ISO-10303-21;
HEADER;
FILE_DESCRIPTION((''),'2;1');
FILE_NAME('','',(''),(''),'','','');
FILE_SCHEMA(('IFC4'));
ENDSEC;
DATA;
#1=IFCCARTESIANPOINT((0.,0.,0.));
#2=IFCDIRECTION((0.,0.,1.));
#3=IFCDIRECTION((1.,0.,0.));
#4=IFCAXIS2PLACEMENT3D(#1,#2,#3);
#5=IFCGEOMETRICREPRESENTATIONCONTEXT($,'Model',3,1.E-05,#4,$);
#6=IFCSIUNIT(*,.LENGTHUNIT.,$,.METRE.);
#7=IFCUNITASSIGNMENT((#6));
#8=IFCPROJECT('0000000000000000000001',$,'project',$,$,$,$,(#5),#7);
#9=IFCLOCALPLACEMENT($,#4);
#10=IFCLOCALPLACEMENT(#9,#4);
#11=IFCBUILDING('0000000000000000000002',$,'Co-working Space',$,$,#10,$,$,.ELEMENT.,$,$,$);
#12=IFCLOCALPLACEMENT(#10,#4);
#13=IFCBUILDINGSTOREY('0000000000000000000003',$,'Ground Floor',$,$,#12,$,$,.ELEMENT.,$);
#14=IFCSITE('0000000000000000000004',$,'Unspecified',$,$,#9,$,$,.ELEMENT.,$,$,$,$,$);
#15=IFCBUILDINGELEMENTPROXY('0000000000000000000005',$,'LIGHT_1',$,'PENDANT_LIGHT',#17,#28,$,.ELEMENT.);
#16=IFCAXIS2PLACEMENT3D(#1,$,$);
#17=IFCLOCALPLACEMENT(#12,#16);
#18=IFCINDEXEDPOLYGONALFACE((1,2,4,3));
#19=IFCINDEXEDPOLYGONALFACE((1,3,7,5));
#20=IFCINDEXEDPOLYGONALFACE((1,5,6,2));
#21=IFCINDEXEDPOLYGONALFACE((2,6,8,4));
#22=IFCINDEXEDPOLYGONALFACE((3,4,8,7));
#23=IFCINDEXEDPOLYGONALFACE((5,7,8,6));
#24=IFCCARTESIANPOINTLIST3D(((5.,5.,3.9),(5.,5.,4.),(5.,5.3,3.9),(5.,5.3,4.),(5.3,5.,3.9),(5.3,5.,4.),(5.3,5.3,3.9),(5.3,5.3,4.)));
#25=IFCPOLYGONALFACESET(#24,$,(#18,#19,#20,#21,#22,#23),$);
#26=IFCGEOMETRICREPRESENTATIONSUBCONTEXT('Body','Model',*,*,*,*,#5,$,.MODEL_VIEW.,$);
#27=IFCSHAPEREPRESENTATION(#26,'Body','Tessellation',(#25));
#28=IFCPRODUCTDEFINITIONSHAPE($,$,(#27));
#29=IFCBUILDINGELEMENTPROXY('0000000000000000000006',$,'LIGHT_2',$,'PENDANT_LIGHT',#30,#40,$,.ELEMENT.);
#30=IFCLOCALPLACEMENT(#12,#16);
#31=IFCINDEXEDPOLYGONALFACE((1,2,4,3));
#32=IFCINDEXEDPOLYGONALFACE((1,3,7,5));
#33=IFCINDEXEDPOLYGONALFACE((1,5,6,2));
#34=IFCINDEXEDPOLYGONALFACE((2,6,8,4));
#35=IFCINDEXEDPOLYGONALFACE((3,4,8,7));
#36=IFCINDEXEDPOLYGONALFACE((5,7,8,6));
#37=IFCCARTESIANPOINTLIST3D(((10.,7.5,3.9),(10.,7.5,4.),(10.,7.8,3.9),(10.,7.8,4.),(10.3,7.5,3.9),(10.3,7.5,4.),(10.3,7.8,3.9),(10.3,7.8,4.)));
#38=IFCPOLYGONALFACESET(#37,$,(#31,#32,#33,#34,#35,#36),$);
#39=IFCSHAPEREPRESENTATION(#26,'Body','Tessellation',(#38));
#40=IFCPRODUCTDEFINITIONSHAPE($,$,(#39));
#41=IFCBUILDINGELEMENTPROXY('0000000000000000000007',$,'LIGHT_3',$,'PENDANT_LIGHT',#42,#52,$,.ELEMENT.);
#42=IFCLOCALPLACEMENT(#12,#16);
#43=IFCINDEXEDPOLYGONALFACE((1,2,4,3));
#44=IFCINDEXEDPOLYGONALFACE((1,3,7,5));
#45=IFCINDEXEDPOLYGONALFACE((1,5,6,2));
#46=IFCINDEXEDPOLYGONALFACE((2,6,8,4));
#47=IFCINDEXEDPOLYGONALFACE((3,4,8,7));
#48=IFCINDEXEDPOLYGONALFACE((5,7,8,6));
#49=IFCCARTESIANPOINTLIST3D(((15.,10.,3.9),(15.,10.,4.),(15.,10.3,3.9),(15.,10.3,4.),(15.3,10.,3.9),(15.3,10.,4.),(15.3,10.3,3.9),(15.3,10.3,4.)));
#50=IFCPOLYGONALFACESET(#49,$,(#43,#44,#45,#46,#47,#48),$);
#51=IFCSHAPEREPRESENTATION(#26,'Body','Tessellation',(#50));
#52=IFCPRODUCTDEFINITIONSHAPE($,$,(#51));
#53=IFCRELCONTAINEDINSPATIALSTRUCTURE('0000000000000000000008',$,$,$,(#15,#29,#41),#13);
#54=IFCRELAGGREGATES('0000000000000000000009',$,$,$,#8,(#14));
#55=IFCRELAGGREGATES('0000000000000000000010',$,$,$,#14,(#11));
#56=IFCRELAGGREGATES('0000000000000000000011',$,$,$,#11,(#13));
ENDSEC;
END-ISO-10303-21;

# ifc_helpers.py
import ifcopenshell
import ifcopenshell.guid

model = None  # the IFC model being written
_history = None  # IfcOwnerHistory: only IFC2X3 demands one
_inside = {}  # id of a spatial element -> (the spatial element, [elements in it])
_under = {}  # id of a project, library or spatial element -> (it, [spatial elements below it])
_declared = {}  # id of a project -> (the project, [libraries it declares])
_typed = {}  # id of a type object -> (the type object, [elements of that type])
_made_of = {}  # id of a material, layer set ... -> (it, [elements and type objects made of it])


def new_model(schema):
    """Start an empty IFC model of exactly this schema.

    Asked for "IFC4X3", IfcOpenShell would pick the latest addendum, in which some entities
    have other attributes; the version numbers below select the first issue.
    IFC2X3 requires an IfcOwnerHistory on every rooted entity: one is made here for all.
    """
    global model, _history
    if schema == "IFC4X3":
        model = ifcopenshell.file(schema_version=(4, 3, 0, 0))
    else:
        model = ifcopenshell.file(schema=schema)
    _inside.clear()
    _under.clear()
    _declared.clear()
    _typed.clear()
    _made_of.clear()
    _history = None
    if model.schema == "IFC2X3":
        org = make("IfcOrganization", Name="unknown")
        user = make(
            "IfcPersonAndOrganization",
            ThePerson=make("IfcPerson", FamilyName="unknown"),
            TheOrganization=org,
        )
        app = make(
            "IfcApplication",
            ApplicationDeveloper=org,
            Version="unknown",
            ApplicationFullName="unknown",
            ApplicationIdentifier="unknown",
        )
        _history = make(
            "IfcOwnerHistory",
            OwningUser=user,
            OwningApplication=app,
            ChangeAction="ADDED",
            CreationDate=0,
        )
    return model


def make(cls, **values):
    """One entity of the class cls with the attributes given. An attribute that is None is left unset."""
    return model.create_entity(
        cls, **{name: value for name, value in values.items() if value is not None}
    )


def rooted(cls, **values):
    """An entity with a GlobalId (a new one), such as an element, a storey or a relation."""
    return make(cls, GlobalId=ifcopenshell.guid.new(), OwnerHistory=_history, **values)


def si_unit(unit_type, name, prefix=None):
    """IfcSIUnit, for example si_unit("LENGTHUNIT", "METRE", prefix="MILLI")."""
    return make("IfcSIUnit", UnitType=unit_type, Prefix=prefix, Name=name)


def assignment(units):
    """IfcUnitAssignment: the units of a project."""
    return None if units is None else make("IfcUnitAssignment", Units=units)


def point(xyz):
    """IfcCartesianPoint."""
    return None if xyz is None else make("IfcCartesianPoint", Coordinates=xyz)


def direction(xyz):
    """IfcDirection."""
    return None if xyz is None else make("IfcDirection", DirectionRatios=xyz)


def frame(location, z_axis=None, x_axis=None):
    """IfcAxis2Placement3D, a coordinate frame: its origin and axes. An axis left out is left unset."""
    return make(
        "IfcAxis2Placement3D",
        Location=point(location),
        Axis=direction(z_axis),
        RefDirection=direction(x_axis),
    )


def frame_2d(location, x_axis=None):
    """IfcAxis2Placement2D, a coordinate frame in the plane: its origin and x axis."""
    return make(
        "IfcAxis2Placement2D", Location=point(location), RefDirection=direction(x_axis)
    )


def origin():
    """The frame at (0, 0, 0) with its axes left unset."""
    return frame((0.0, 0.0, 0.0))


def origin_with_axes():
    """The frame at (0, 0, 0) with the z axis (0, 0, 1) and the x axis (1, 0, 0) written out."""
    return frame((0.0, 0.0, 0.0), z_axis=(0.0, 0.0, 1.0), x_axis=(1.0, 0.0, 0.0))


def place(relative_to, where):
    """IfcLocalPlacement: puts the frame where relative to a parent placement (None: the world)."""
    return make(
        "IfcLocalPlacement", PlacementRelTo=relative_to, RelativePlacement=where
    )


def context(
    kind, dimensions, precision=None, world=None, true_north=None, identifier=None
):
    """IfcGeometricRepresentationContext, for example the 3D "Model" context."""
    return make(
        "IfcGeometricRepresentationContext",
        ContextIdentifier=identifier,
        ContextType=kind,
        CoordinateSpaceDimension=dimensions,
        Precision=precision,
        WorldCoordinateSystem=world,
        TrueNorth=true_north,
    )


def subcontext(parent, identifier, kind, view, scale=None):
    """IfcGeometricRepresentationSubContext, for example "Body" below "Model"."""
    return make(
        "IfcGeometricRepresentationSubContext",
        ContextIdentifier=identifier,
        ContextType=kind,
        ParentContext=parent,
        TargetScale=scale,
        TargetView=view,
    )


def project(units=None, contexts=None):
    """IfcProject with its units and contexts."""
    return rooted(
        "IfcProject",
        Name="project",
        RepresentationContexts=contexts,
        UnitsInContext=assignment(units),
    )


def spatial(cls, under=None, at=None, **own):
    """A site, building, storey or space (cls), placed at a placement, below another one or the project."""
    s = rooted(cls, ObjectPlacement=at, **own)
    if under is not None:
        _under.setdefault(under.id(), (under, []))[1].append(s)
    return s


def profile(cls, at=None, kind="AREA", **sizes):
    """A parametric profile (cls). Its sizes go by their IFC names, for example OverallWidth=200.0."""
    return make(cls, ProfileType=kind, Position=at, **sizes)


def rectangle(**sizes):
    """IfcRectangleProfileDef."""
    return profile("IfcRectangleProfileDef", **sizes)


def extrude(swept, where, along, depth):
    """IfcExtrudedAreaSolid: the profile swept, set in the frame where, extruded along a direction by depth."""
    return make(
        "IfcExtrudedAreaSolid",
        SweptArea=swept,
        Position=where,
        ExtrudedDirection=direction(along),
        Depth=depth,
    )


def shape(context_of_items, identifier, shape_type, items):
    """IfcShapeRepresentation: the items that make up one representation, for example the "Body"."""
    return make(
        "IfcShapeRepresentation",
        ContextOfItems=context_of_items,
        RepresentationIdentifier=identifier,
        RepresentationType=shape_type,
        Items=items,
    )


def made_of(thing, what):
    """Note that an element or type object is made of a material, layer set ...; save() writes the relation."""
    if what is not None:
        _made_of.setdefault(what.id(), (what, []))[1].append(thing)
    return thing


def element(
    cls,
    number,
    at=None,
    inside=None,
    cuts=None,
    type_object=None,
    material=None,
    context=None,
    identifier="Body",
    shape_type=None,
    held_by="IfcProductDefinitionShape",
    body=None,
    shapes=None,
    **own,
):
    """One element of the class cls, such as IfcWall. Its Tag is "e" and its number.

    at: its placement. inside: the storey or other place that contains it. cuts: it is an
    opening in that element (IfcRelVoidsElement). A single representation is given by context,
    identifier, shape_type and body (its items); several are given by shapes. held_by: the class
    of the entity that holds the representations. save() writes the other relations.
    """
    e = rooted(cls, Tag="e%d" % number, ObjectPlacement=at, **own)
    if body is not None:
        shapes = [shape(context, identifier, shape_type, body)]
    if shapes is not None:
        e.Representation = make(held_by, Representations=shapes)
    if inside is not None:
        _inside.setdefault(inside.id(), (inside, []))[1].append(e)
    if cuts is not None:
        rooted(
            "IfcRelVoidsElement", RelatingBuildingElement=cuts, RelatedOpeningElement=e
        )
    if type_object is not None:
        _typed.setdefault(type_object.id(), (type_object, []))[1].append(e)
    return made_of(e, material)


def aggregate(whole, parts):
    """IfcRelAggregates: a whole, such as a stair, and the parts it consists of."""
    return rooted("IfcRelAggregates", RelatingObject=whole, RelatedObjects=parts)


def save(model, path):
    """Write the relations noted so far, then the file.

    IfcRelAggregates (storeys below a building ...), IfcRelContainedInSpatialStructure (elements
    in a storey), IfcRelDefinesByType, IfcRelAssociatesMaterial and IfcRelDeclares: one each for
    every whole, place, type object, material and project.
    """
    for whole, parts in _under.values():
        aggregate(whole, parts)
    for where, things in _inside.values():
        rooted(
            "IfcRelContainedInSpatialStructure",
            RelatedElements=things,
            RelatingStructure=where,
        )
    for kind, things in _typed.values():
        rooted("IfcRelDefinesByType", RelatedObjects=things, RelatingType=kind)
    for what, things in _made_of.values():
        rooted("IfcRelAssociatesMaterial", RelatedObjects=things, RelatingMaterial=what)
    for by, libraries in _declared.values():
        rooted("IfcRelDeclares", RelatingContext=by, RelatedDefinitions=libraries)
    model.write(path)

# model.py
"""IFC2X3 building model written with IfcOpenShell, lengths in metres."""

from ifc_helpers import new_model, si_unit, frame, frame_2d, origin, origin_with_axes, place, context, subcontext, project, spatial, rectangle, extrude, element, save


model = new_model("IFC2X3")

# Units and contexts
model_context = context("Model", 3, precision=1e-05, world=origin_with_axes())
body_context = subcontext(model_context, "Body", "Model", "MODEL_VIEW")
ifc_project = project(units=[si_unit("LENGTHUNIT", "METRE")], contexts=[model_context])

# Site, building, storey
site_placement = place(None, origin_with_axes())
site = spatial("IfcSite", under=ifc_project, at=site_placement, Name="Unspecified", CompositionType="ELEMENT")
building_placement = place(site_placement, origin_with_axes())
building = spatial("IfcBuilding", under=site, at=building_placement, Name="Co-working Space", CompositionType="ELEMENT")
storey_placement = place(building_placement, origin_with_axes())
storey = spatial("IfcBuildingStorey", under=building, at=storey_placement, Name="Ground Floor", CompositionType="ELEMENT")

# Building element proxies
for number, where, z_axis, x_axis, name in (
    (1, (5.0, 5.0, 3.9), (0.0, 0.0, 1.0), (1.0, 0.0, 0.0), "LIGHT_1"),
    (2, (10.0, 7.5, 3.9), (0.0, 0.0, 1.0), (1.0, 0.0, 0.0), "LIGHT_2"),
    (3, (15.0, 10.0, 3.9), (0.0, 0.0, 1.0), (1.0, 0.0, 0.0), "LIGHT_3"),
):
    element("IfcBuildingElementProxy", number, at=place(storey_placement, frame(where, z_axis=z_axis, x_axis=x_axis)), inside=storey, Name=name, ObjectType="PENDANT_LIGHT", CompositionType="ELEMENT", context=body_context, shape_type="SweptSolid", body=[
        extrude(rectangle(XDim=0.3, YDim=0.3, at=frame_2d((0.15, 0.15))), origin(), (0.0, 0.0, 1.0), 0.1),
    ])

save(model, "model.ifc")
